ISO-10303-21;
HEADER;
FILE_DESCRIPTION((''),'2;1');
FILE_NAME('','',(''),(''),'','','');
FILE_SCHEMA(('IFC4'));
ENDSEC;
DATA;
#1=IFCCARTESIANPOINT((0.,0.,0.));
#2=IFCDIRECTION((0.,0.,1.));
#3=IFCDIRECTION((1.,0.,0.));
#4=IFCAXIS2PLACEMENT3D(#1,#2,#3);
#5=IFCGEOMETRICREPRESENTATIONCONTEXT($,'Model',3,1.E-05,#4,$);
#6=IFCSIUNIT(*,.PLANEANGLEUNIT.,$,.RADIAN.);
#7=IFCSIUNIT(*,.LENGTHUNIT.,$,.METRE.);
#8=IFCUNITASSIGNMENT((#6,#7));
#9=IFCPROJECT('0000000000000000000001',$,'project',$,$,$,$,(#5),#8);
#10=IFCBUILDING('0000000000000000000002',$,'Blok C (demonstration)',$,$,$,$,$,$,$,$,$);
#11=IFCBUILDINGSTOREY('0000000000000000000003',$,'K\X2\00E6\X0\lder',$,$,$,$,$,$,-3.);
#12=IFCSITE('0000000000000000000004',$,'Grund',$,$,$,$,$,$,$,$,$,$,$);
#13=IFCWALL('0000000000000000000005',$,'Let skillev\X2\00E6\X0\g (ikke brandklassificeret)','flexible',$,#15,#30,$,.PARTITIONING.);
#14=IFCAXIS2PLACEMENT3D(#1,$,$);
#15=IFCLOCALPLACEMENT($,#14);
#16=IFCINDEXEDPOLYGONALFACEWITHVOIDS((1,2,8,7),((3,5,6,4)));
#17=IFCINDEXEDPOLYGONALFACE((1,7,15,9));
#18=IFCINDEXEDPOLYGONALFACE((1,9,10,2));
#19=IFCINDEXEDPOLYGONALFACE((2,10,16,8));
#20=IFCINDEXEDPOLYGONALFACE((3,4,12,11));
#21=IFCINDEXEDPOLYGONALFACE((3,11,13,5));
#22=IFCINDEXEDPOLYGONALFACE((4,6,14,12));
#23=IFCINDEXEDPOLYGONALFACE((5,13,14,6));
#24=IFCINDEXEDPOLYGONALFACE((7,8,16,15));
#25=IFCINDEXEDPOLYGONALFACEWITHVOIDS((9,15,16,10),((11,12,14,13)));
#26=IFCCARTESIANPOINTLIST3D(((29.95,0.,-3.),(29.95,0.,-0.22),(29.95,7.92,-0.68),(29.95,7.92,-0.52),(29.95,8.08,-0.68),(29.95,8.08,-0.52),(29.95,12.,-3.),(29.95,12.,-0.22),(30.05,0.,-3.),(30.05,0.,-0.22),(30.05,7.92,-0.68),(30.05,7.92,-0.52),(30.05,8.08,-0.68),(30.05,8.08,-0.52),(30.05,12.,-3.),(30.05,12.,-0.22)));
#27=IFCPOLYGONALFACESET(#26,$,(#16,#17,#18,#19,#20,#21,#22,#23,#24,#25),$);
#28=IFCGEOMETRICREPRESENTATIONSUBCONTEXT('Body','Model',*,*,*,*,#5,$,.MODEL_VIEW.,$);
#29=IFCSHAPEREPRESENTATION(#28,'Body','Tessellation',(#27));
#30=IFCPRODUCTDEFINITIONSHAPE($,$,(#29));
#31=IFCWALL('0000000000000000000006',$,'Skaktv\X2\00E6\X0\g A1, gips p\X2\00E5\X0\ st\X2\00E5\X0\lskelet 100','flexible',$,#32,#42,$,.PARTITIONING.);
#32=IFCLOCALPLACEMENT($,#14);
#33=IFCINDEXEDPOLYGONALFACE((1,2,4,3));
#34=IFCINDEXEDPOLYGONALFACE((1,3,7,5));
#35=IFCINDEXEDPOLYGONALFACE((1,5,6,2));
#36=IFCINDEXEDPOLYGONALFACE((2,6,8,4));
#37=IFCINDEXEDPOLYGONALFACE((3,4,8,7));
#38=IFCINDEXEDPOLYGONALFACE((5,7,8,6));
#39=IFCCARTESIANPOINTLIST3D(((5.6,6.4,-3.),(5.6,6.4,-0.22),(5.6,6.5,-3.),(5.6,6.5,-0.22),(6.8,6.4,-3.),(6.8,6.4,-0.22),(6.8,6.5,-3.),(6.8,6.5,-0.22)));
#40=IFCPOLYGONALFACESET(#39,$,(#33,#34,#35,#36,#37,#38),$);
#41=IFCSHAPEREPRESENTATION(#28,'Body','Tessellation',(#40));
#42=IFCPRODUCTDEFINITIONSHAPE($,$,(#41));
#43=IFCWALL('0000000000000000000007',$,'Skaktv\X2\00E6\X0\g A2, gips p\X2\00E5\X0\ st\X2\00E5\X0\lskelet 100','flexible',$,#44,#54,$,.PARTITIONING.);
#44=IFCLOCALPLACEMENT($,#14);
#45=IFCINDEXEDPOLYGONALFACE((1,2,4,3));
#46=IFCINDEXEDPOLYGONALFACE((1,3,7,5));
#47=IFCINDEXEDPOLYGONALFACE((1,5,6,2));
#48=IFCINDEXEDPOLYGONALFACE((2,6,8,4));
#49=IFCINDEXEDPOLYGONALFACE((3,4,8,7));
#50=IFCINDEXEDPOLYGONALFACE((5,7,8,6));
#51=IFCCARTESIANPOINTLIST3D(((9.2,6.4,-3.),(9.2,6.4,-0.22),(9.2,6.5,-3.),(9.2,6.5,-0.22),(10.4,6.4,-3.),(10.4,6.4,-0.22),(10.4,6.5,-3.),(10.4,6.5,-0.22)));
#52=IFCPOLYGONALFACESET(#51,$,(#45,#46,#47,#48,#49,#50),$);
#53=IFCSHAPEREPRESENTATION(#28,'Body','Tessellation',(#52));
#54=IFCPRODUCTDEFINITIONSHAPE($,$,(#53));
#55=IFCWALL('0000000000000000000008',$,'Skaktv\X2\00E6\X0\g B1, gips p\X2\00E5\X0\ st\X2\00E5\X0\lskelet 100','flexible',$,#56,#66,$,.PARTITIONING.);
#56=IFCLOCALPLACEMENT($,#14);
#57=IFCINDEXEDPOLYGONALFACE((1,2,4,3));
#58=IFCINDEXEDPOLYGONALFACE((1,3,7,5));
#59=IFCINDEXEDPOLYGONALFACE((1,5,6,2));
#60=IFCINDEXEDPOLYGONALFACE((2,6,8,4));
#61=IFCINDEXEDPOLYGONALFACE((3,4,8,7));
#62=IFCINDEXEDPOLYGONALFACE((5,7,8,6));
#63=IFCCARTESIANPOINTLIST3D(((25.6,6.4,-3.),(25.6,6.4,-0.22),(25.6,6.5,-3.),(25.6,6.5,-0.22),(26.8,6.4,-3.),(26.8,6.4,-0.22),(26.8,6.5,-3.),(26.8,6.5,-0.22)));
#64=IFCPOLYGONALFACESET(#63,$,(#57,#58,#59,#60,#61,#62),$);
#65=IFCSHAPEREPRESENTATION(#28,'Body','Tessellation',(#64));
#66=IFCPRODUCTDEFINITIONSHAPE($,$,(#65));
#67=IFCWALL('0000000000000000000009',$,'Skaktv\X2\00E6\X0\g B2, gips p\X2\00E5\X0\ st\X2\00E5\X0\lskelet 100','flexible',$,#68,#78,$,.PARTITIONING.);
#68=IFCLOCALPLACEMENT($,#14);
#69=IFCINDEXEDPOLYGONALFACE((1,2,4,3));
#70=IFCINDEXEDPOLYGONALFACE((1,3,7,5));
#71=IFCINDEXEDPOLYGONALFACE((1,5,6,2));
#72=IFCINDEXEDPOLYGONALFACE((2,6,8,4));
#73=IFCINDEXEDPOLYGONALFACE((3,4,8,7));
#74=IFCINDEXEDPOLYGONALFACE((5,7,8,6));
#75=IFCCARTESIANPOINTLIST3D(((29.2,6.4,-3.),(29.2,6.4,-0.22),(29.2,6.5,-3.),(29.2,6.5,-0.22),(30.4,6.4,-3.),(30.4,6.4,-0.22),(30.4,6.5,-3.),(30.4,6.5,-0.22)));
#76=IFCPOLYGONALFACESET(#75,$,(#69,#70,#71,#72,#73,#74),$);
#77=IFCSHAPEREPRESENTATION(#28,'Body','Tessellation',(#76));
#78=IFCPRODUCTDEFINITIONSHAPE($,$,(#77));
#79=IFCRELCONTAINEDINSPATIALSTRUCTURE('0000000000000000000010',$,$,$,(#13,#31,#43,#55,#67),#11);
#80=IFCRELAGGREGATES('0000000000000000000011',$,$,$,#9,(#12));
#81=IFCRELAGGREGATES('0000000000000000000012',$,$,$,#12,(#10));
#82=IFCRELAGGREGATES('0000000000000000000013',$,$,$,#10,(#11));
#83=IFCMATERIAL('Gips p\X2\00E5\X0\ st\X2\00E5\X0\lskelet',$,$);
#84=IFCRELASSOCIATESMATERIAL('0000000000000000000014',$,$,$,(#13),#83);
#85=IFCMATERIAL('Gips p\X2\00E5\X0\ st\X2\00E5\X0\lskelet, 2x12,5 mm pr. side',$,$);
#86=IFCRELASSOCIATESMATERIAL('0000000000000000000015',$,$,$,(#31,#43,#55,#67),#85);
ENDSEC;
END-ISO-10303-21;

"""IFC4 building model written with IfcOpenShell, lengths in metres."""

from ifc_helpers import new_model, si_unit, frame, origin_with_axes, place, context, subcontext, project, spatial, polyline, outline, extrude, material, element, save


model = new_model("IFC4")

# Units and contexts
model_context = context("Model", 3, precision=1e-05, world=origin_with_axes())
body_context = subcontext(model_context, "Body", "Model", "MODEL_VIEW")
ifc_project = project(units=[si_unit("PLANEANGLEUNIT", "RADIAN"), si_unit("LENGTHUNIT", "METRE")], contexts=[model_context])

# Site, building, storey
site = spatial("IfcSite", under=ifc_project, Name="Grund")
building = spatial("IfcBuilding", under=site, Name="Blok C (demonstration)")
storey = spatial("IfcBuildingStorey", under=building, Name="Kælder", Elevation=-3.0)

# Wall, opening
ifc_material_1 = material(Name="Gips på stålskelet")
wall_1_placement = place(None, origin_with_axes())
wall_1 = element("IfcWall", 1, at=wall_1_placement, inside=storey, material=ifc_material_1, Name="Let skillevæg (ikke brandklassificeret)", Description="flexible", PredefinedType="PARTITIONING", context=body_context, shape_type="SweptSolid", body=[
    extrude(outline(polyline([(29.95, 0.0), (30.05, 0.0), (30.05, 12.0), (29.95, 12.0), (29.95, 0.0)])), frame((0.0, 0.0, -3.0)), (0.0, 0.0, 1.0), 2.78),
])
opening_placement = place(wall_1_placement, origin_with_axes())
element("IfcOpeningElement", 2, at=opening_placement, cuts=wall_1, PredefinedType="OPENING", context=body_context, shape_type="SweptSolid", body=[
    extrude(outline(polyline([(29.88, 7.92), (30.12, 7.92), (30.12, 8.08), (29.88, 8.08), (29.88, 7.92)])), frame((0.0, 0.0, -0.68)), (0.0, 0.0, 1.0), 0.16),
])

# Walls
ifc_material_2 = material(Name="Gips på stålskelet, 2x12,5 mm pr. side")
wall_2_placement = place(None, origin_with_axes())
element("IfcWall", 3, at=wall_2_placement, inside=storey, material=ifc_material_2, Name="Skaktvæg A1, gips på stålskelet 100", Description="flexible", PredefinedType="PARTITIONING", context=body_context, shape_type="SweptSolid", body=[
    extrude(outline(polyline([(5.6, 6.4), (6.8, 6.4), (6.8, 6.5), (5.6, 6.5), (5.6, 6.4)])), frame((0.0, 0.0, -3.0)), (0.0, 0.0, 1.0), 2.78),
])
wall_3_placement = place(None, origin_with_axes())
element("IfcWall", 4, at=wall_3_placement, inside=storey, material=ifc_material_2, Name="Skaktvæg A2, gips på stålskelet 100", Description="flexible", PredefinedType="PARTITIONING", context=body_context, shape_type="SweptSolid", body=[
    extrude(outline(polyline([(9.2, 6.4), (10.4, 6.4), (10.4, 6.5), (9.2, 6.5), (9.2, 6.4)])), frame((0.0, 0.0, -3.0)), (0.0, 0.0, 1.0), 2.78),
])
wall_4_placement = place(None, origin_with_axes())
element("IfcWall", 5, at=wall_4_placement, inside=storey, material=ifc_material_2, Name="Skaktvæg B1, gips på stålskelet 100", Description="flexible", PredefinedType="PARTITIONING", context=body_context, shape_type="SweptSolid", body=[
    extrude(outline(polyline([(25.6, 6.4), (26.8, 6.4), (26.8, 6.5), (25.6, 6.5), (25.6, 6.4)])), frame((0.0, 0.0, -3.0)), (0.0, 0.0, 1.0), 2.78),
])
wall_5_placement = place(None, origin_with_axes())
element("IfcWall", 6, at=wall_5_placement, inside=storey, material=ifc_material_2, Name="Skaktvæg B2, gips på stålskelet 100", Description="flexible", PredefinedType="PARTITIONING", context=body_context, shape_type="SweptSolid", body=[
    extrude(outline(polyline([(29.2, 6.4), (30.4, 6.4), (30.4, 6.5), (29.2, 6.5), (29.2, 6.4)])), frame((0.0, 0.0, -3.0)), (0.0, 0.0, 1.0), 2.78),
])

save(model, "model.ifc")
